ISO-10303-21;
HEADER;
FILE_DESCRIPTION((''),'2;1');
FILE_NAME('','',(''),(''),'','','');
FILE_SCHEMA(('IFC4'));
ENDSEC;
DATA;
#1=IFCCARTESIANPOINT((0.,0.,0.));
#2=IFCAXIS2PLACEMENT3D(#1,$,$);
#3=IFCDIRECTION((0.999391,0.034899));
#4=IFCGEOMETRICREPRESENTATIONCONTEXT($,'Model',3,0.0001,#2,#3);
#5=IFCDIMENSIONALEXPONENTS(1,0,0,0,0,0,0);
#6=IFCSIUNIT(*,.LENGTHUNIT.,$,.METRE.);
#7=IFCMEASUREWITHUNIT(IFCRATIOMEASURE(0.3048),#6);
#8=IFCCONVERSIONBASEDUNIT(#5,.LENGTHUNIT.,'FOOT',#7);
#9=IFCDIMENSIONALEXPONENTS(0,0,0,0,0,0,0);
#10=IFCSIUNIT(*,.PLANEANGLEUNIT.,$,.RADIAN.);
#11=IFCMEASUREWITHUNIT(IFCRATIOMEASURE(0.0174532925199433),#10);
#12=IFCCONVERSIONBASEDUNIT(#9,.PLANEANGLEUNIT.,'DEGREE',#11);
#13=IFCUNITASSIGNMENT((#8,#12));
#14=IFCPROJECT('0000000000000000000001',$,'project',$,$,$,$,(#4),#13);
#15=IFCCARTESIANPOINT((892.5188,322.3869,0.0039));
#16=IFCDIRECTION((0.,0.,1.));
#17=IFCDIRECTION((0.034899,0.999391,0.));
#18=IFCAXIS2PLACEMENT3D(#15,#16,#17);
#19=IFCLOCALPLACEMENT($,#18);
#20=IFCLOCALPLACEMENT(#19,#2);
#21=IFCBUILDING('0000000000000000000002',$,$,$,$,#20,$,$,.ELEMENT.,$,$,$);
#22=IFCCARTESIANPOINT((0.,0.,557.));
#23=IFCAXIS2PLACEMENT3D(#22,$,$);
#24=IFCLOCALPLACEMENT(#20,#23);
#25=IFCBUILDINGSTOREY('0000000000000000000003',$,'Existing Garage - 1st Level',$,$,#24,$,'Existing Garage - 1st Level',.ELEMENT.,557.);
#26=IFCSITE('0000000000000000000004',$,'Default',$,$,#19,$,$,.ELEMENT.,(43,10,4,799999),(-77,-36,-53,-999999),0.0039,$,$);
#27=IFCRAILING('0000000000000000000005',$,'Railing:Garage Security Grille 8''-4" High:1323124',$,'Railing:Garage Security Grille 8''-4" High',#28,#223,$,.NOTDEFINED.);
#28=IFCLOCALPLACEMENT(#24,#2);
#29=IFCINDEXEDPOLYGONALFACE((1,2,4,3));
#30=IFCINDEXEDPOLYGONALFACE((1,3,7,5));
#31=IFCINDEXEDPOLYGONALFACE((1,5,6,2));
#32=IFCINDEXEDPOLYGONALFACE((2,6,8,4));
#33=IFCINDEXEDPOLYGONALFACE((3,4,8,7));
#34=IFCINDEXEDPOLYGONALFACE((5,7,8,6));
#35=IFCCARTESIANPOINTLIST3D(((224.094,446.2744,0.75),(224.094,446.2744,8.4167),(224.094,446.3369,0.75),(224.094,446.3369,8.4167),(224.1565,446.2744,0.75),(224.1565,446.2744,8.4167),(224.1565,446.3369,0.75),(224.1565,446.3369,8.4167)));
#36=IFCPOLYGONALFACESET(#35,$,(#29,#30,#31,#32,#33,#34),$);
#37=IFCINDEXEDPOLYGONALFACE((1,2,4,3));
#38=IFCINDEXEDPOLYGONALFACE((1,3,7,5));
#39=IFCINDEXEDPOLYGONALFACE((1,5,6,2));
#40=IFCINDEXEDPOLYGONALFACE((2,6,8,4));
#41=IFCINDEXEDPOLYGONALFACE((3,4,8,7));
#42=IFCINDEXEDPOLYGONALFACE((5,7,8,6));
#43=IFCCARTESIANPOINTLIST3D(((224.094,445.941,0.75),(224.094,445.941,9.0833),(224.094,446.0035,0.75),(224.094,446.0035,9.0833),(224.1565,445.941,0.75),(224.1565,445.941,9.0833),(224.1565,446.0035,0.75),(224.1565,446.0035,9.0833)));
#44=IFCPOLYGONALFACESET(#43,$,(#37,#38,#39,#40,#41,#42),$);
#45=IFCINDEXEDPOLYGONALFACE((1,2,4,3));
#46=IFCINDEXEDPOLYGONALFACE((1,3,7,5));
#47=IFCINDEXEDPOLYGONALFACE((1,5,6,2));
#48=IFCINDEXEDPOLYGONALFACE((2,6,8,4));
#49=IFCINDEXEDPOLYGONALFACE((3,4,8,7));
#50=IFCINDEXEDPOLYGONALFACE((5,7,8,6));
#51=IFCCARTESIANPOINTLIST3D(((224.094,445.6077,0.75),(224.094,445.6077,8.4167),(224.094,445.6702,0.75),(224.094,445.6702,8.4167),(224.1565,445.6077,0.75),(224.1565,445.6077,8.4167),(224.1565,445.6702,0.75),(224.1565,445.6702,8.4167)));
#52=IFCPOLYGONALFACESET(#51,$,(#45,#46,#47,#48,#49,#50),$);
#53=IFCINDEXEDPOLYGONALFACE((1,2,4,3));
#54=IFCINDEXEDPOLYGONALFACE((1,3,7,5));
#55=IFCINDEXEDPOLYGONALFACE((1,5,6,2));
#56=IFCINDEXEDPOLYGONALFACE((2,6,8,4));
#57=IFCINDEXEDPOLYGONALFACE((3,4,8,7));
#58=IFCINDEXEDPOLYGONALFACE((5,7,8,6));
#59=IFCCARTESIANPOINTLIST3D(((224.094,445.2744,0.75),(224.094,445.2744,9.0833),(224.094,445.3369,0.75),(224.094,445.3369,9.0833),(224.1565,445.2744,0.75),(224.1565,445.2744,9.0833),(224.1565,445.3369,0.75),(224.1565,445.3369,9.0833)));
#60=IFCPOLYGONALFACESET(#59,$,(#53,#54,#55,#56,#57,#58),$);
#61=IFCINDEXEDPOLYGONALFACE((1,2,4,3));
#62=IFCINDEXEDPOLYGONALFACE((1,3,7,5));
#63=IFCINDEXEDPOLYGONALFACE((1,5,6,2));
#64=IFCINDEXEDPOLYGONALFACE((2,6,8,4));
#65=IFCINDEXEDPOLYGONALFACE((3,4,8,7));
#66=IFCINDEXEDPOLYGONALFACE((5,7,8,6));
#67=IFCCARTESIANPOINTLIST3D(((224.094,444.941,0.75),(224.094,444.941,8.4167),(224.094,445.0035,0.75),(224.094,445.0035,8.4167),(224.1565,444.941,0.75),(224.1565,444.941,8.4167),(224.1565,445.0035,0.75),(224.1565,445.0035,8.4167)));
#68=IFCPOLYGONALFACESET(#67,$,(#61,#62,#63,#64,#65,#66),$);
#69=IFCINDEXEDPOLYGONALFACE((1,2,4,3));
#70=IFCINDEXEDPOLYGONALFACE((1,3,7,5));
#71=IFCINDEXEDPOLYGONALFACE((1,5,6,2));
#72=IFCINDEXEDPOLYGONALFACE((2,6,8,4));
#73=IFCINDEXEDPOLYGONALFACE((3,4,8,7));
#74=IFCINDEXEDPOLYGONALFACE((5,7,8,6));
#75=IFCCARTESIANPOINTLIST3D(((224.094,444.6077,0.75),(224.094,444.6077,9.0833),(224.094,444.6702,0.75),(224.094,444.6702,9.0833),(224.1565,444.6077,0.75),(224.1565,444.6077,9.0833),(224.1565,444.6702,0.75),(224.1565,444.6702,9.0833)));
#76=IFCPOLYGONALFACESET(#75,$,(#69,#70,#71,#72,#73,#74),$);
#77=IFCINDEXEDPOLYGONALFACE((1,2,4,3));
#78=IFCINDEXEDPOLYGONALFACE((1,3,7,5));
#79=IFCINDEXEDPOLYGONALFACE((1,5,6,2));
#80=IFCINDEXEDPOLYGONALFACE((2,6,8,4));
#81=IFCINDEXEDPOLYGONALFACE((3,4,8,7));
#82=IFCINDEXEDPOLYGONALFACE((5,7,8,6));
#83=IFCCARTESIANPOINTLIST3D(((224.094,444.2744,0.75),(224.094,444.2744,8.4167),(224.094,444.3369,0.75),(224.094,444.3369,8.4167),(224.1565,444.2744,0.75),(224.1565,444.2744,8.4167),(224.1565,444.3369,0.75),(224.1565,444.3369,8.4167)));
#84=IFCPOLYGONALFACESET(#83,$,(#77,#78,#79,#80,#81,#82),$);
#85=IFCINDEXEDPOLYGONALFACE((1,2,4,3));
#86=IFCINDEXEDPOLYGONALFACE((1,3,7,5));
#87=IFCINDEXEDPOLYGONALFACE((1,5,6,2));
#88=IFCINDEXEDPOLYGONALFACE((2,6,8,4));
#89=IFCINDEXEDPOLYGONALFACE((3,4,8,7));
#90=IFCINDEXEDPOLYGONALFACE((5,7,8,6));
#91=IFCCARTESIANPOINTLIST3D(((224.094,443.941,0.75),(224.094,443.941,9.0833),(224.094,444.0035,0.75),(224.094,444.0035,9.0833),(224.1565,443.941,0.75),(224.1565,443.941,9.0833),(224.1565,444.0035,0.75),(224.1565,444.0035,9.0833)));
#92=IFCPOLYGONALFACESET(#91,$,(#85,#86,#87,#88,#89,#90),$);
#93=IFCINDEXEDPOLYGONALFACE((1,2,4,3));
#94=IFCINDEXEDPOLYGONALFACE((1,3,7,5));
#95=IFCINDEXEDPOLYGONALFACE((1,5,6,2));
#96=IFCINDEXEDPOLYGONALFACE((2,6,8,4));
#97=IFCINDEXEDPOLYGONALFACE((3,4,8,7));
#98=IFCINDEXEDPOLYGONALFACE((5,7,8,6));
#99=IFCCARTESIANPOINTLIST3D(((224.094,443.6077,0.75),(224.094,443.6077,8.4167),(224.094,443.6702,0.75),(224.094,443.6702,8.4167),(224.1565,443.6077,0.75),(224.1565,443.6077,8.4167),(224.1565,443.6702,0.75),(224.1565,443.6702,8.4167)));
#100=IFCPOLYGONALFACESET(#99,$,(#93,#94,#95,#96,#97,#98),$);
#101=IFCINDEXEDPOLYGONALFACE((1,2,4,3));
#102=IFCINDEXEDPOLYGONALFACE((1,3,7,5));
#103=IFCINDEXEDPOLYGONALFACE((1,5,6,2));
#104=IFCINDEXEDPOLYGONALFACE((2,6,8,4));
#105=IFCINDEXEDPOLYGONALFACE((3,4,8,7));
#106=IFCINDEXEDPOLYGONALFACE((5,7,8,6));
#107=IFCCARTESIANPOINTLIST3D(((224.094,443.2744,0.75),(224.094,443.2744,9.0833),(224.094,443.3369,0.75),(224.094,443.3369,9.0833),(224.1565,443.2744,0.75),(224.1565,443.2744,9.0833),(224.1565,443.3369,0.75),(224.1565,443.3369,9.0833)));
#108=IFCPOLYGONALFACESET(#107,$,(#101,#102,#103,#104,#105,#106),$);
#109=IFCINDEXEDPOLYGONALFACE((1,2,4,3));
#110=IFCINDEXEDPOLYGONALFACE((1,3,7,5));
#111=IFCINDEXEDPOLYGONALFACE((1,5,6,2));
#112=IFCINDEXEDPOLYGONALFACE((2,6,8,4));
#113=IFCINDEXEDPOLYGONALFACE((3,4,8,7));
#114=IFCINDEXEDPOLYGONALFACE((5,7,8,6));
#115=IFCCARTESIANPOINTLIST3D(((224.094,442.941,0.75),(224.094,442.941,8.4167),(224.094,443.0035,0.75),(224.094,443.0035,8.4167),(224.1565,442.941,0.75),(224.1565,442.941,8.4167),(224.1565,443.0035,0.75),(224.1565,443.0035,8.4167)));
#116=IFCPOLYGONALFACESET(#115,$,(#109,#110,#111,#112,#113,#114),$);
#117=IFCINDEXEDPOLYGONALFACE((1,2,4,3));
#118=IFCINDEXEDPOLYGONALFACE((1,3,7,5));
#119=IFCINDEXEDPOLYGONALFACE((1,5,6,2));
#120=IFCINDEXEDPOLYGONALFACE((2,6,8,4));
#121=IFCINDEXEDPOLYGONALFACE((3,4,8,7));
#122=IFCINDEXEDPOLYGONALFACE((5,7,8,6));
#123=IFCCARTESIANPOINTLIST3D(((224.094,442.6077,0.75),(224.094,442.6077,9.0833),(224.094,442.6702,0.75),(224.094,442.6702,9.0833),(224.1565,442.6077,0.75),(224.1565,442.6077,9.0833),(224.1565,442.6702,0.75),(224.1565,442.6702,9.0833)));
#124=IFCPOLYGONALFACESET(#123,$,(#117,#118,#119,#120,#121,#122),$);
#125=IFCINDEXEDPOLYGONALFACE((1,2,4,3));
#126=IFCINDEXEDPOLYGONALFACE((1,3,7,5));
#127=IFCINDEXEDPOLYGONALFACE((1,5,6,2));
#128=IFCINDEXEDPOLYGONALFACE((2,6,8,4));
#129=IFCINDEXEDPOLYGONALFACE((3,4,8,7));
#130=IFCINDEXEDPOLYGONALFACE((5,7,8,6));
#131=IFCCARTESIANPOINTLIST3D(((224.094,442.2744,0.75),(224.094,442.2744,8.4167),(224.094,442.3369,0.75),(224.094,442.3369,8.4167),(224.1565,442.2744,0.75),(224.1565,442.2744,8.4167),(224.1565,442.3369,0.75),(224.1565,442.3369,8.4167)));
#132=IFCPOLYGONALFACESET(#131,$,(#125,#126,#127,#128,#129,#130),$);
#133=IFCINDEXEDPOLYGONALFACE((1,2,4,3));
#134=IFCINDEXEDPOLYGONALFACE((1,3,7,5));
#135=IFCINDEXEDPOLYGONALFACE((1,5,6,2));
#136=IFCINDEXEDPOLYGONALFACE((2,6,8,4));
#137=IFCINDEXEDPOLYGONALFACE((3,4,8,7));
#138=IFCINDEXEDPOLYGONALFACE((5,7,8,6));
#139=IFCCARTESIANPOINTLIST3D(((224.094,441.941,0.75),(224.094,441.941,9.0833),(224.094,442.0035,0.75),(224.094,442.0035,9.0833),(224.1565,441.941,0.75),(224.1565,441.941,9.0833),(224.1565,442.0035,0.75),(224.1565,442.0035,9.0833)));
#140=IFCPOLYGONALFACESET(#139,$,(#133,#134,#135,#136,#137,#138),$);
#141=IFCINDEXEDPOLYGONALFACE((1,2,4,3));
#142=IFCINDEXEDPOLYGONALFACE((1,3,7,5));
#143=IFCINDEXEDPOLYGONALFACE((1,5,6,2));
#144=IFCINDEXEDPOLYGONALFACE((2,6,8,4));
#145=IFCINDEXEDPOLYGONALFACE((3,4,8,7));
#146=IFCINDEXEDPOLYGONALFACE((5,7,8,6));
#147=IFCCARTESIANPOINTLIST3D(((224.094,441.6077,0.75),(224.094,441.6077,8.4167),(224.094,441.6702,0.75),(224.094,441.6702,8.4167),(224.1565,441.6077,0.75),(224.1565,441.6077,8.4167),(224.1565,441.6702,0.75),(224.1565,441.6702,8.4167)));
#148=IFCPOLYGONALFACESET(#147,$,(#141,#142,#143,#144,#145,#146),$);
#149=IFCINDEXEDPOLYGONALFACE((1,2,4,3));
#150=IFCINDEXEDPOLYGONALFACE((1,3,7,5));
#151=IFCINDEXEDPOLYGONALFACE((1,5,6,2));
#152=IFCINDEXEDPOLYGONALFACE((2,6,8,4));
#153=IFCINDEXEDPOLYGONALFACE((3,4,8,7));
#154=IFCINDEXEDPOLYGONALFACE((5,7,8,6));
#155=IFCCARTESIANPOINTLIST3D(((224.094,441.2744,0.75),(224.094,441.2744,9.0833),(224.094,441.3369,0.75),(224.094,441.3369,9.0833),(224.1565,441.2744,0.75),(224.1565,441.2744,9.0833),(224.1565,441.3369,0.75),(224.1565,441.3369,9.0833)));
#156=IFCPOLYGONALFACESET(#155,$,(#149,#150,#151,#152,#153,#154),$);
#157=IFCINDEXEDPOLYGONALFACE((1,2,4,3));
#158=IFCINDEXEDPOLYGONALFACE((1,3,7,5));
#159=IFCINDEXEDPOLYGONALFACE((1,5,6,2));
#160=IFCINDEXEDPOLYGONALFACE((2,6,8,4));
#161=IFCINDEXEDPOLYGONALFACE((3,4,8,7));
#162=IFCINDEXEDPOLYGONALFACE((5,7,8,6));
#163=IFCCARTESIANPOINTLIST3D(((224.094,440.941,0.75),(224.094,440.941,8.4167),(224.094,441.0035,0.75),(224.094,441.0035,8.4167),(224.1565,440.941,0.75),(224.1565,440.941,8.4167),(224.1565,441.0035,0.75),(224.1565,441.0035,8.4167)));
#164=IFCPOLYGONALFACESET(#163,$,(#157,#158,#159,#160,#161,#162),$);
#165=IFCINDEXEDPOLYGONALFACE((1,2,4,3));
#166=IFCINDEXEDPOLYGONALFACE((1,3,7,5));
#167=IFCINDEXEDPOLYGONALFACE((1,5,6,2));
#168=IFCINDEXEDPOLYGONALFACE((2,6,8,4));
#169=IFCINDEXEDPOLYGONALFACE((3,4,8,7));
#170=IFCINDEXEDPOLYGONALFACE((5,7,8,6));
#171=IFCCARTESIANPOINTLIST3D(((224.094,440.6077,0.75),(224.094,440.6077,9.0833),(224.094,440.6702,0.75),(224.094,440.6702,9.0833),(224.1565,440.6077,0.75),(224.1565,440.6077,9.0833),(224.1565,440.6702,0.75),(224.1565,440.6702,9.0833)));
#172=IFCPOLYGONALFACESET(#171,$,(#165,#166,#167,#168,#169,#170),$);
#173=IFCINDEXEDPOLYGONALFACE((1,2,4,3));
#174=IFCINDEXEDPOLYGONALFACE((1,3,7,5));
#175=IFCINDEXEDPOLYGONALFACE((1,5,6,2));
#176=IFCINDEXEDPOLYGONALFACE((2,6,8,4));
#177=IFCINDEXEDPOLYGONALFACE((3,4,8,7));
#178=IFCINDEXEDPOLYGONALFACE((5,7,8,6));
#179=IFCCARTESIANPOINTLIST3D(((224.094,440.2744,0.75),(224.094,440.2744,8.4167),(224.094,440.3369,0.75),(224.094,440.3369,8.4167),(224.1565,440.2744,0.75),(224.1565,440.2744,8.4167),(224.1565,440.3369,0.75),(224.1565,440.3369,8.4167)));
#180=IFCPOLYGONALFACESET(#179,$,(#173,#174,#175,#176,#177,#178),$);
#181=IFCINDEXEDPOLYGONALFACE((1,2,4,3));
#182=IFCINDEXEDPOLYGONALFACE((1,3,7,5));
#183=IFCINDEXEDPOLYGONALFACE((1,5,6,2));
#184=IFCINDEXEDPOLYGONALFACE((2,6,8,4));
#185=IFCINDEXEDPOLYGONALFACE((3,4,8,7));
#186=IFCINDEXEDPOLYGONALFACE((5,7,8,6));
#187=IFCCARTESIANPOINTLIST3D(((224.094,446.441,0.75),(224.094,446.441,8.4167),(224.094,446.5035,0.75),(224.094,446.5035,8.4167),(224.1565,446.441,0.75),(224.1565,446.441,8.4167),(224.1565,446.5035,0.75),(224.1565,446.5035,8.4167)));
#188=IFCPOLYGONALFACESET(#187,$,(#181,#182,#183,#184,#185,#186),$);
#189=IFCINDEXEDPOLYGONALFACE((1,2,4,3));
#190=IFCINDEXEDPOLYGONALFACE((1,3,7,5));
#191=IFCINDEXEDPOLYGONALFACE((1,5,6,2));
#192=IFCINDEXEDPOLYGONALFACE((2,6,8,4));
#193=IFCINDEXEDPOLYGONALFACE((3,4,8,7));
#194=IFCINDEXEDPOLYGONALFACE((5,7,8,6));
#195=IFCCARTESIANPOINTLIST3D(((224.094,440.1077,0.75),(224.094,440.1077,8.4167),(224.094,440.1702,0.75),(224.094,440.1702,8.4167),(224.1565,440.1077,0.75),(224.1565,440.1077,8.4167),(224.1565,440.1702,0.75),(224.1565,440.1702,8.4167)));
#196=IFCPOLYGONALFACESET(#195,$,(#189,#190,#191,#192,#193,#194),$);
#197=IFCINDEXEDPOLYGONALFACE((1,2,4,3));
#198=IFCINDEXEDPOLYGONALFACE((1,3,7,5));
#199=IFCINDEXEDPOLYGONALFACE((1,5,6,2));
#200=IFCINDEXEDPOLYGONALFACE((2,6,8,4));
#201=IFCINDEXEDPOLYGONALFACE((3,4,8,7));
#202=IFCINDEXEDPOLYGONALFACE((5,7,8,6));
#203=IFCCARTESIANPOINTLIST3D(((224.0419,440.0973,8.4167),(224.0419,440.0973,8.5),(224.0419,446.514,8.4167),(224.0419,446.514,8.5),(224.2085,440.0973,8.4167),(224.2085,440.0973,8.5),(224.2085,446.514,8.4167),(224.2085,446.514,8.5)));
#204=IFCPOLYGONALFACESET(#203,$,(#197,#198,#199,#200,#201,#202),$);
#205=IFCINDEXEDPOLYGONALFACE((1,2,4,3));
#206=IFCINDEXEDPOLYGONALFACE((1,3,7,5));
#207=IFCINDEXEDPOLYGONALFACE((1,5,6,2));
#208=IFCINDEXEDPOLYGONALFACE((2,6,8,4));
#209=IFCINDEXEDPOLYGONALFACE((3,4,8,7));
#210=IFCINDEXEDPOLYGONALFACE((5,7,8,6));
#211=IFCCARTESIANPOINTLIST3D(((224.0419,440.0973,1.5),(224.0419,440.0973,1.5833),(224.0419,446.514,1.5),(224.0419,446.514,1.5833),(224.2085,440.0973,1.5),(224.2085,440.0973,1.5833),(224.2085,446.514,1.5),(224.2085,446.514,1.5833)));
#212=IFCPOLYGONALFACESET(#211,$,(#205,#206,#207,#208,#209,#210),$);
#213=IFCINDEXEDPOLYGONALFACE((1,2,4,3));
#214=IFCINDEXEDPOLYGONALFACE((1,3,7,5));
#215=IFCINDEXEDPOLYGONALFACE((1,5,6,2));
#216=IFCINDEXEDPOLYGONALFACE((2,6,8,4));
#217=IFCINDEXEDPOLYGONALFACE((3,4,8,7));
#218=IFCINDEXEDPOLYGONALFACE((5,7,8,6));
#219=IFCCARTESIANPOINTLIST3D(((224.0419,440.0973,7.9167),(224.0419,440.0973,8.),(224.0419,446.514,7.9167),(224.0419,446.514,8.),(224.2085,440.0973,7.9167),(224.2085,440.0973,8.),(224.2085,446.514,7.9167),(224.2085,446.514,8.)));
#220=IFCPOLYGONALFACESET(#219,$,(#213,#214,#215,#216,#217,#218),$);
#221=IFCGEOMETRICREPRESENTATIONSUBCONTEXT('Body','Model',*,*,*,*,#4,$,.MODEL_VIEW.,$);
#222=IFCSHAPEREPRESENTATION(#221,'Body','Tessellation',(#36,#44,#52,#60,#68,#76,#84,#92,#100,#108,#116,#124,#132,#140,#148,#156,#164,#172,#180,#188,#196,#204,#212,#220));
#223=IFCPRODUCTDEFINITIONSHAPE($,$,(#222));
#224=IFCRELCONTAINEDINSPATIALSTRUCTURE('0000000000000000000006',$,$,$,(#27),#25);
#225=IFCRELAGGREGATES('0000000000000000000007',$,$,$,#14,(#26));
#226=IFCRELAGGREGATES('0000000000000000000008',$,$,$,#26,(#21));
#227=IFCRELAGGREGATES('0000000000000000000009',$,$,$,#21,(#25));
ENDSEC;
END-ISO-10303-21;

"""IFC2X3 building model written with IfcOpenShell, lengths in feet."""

from ifc_helpers import new_model, entity, si_unit, converted_unit, direction, frame, frame_2d, origin, origin_2d_with_axis, place, context, subcontext, project, spatial, rectangle, extrude, element, save


model = new_model("IFC2X3")

# Units and contexts
model_context = context("Model", 3, precision=0.0001, world=origin(), true_north=direction((0.999391, 0.034899)))
body_context = subcontext(model_context, "Body", "Model", "MODEL_VIEW")
ifc_project = project(units=[converted_unit("LENGTHUNIT", "FOOT", entity("IfcRatioMeasure", 0.3048), si_unit("LENGTHUNIT", "METRE"), dimensions=[1, 0, 0, 0, 0, 0, 0]), converted_unit("PLANEANGLEUNIT", "DEGREE", entity("IfcRatioMeasure", 0.0174532925199433), si_unit("PLANEANGLEUNIT", "RADIAN"), dimensions=[0, 0, 0, 0, 0, 0, 0])], contexts=[model_context])

# Site, building, storey
site_placement = place(None, frame((892.5188, 322.3869, 0.0039), z_axis=(0.0, 0.0, 1.0), x_axis=(0.034899, 0.999391, 0.0)))
site = spatial("IfcSite", under=ifc_project, at=site_placement, Name="Default", CompositionType="ELEMENT", RefLatitude=(43, 10, 4, 799999), RefLongitude=(-77, -36, -53, -999999), RefElevation=0.0039)
building_placement = place(site_placement, origin())
building = spatial("IfcBuilding", under=site, at=building_placement, CompositionType="ELEMENT")
storey_placement = place(building_placement, frame((0.0, 0.0, 557.0)))
storey = spatial("IfcBuildingStorey", under=building, at=storey_placement, Name="Existing Garage - 1st Level", LongName="Existing Garage - 1st Level", CompositionType="ELEMENT", Elevation=557.0)

# Railing
railing_1_placement = place(storey_placement, origin())
element("IfcRailing", 1, at=railing_1_placement, inside=storey, Name="Railing:Garage Security Grille 8'-4\" High:1323124", ObjectType="Railing:Garage Security Grille 8'-4\" High", PredefinedType="NOTDEFINED", context=body_context, shape_type="SweptSolid", body=[
    extrude(rectangle(XDim=0.0625, YDim=0.0625, at=origin_2d_with_axis()), frame((224.1252, 446.3056, 0.75), z_axis=(0.0, 0.0, 1.0), x_axis=(0.0, 1.0, 0.0)), (0.0, 0.0, 1.0), 7.6667),
    extrude(rectangle(XDim=0.0625, YDim=0.0625, at=origin_2d_with_axis()), frame((224.1252, 445.9723, 0.75), z_axis=(0.0, 0.0, 1.0), x_axis=(0.0, 1.0, 0.0)), (0.0, 0.0, 1.0), 8.3333),
    extrude(rectangle(XDim=0.0625, YDim=0.0625, at=origin_2d_with_axis()), frame((224.1252, 445.639, 0.75), z_axis=(0.0, 0.0, 1.0), x_axis=(0.0, 1.0, 0.0)), (0.0, 0.0, 1.0), 7.6667),
    extrude(rectangle(XDim=0.0625, YDim=0.0625, at=origin_2d_with_axis()), frame((224.1252, 445.3056, 0.75), z_axis=(0.0, 0.0, 1.0), x_axis=(0.0, 1.0, 0.0)), (0.0, 0.0, 1.0), 8.3333),
    extrude(rectangle(XDim=0.0625, YDim=0.0625, at=origin_2d_with_axis()), frame((224.1252, 444.9723, 0.75), z_axis=(0.0, 0.0, 1.0), x_axis=(0.0, 1.0, 0.0)), (0.0, 0.0, 1.0), 7.6667),
    extrude(rectangle(XDim=0.0625, YDim=0.0625, at=origin_2d_with_axis()), frame((224.1252, 444.639, 0.75), z_axis=(0.0, 0.0, 1.0), x_axis=(0.0, 1.0, 0.0)), (0.0, 0.0, 1.0), 8.3333),
    extrude(rectangle(XDim=0.0625, YDim=0.0625, at=origin_2d_with_axis()), frame((224.1252, 444.3056, 0.75), z_axis=(0.0, 0.0, 1.0), x_axis=(0.0, 1.0, 0.0)), (0.0, 0.0, 1.0), 7.6667),
    extrude(rectangle(XDim=0.0625, YDim=0.0625, at=origin_2d_with_axis()), frame((224.1252, 443.9723, 0.75), z_axis=(0.0, 0.0, 1.0), x_axis=(0.0, 1.0, 0.0)), (0.0, 0.0, 1.0), 8.3333),
    extrude(rectangle(XDim=0.0625, YDim=0.0625, at=origin_2d_with_axis()), frame((224.1252, 443.639, 0.75), z_axis=(0.0, 0.0, 1.0), x_axis=(0.0, 1.0, 0.0)), (0.0, 0.0, 1.0), 7.6667),
    extrude(rectangle(XDim=0.0625, YDim=0.0625, at=origin_2d_with_axis()), frame((224.1252, 443.3056, 0.75), z_axis=(0.0, 0.0, 1.0), x_axis=(0.0, 1.0, 0.0)), (0.0, 0.0, 1.0), 8.3333),
    extrude(rectangle(XDim=0.0625, YDim=0.0625, at=origin_2d_with_axis()), frame((224.1252, 442.9723, 0.75), z_axis=(0.0, 0.0, 1.0), x_axis=(0.0, 1.0, 0.0)), (0.0, 0.0, 1.0), 7.6667),
    extrude(rectangle(XDim=0.0625, YDim=0.0625, at=origin_2d_with_axis()), frame((224.1252, 442.639, 0.75), z_axis=(0.0, 0.0, 1.0), x_axis=(0.0, 1.0, 0.0)), (0.0, 0.0, 1.0), 8.3333),
    extrude(rectangle(XDim=0.0625, YDim=0.0625, at=origin_2d_with_axis()), frame((224.1252, 442.3056, 0.75), z_axis=(0.0, 0.0, 1.0), x_axis=(0.0, 1.0, 0.0)), (0.0, 0.0, 1.0), 7.6667),
    extrude(rectangle(XDim=0.0625, YDim=0.0625, at=origin_2d_with_axis()), frame((224.1252, 441.9723, 0.75), z_axis=(0.0, 0.0, 1.0), x_axis=(0.0, 1.0, 0.0)), (0.0, 0.0, 1.0), 8.3333),
    extrude(rectangle(XDim=0.0625, YDim=0.0625, at=origin_2d_with_axis()), frame((224.1252, 441.639, 0.75), z_axis=(0.0, 0.0, 1.0), x_axis=(0.0, 1.0, 0.0)), (0.0, 0.0, 1.0), 7.6667),
    extrude(rectangle(XDim=0.0625, YDim=0.0625, at=origin_2d_with_axis()), frame((224.1252, 441.3056, 0.75), z_axis=(0.0, 0.0, 1.0), x_axis=(0.0, 1.0, 0.0)), (0.0, 0.0, 1.0), 8.3333),
    extrude(rectangle(XDim=0.0625, YDim=0.0625, at=origin_2d_with_axis()), frame((224.1252, 440.9723, 0.75), z_axis=(0.0, 0.0, 1.0), x_axis=(0.0, 1.0, 0.0)), (0.0, 0.0, 1.0), 7.6667),
    extrude(rectangle(XDim=0.0625, YDim=0.0625, at=origin_2d_with_axis()), frame((224.1252, 440.639, 0.75), z_axis=(0.0, 0.0, 1.0), x_axis=(0.0, 1.0, 0.0)), (0.0, 0.0, 1.0), 8.3333),
    extrude(rectangle(XDim=0.0625, YDim=0.0625, at=origin_2d_with_axis()), frame((224.1252, 440.3056, 0.75), z_axis=(0.0, 0.0, 1.0), x_axis=(0.0, 1.0, 0.0)), (0.0, 0.0, 1.0), 7.6667),
    extrude(rectangle(XDim=0.0625, YDim=0.0625, at=origin_2d_with_axis()), frame((224.1252, 446.4723, 0.75), z_axis=(0.0, 0.0, 1.0), x_axis=(0.0, 1.0, 0.0)), (0.0, 0.0, 1.0), 7.6667),
    extrude(rectangle(XDim=0.0625, YDim=0.0625, at=origin_2d_with_axis()), frame((224.1252, 440.139, 0.75), z_axis=(0.0, 0.0, 1.0), x_axis=(0.0, 1.0, 0.0)), (0.0, 0.0, 1.0), 7.6667),
    extrude(rectangle(XDim=6.4167, YDim=0.1667, at=frame_2d((0.0, 0.0), x_axis=(1.0, 0.0))), frame((224.1252, 443.3056, 8.4167), z_axis=(0.0, 0.0, 1.0), x_axis=(0.0, 1.0, 0.0)), (0.0, 0.0, 1.0), 0.0833),
    extrude(rectangle(XDim=6.4167, YDim=0.1667, at=frame_2d((0.0, 0.0), x_axis=(1.0, 0.0))), frame((224.1252, 443.3056, 1.5), z_axis=(0.0, 0.0, 1.0), x_axis=(0.0, 1.0, 0.0)), (0.0, 0.0, 1.0), 0.0833),
    extrude(rectangle(XDim=6.4167, YDim=0.1667, at=frame_2d((0.0, 0.0), x_axis=(1.0, 0.0))), frame((224.1252, 443.3056, 7.9167), z_axis=(0.0, 0.0, 1.0), x_axis=(0.0, 1.0, 0.0)), (0.0, 0.0, 1.0), 0.0833),
])

save(model, "model.ifc")
